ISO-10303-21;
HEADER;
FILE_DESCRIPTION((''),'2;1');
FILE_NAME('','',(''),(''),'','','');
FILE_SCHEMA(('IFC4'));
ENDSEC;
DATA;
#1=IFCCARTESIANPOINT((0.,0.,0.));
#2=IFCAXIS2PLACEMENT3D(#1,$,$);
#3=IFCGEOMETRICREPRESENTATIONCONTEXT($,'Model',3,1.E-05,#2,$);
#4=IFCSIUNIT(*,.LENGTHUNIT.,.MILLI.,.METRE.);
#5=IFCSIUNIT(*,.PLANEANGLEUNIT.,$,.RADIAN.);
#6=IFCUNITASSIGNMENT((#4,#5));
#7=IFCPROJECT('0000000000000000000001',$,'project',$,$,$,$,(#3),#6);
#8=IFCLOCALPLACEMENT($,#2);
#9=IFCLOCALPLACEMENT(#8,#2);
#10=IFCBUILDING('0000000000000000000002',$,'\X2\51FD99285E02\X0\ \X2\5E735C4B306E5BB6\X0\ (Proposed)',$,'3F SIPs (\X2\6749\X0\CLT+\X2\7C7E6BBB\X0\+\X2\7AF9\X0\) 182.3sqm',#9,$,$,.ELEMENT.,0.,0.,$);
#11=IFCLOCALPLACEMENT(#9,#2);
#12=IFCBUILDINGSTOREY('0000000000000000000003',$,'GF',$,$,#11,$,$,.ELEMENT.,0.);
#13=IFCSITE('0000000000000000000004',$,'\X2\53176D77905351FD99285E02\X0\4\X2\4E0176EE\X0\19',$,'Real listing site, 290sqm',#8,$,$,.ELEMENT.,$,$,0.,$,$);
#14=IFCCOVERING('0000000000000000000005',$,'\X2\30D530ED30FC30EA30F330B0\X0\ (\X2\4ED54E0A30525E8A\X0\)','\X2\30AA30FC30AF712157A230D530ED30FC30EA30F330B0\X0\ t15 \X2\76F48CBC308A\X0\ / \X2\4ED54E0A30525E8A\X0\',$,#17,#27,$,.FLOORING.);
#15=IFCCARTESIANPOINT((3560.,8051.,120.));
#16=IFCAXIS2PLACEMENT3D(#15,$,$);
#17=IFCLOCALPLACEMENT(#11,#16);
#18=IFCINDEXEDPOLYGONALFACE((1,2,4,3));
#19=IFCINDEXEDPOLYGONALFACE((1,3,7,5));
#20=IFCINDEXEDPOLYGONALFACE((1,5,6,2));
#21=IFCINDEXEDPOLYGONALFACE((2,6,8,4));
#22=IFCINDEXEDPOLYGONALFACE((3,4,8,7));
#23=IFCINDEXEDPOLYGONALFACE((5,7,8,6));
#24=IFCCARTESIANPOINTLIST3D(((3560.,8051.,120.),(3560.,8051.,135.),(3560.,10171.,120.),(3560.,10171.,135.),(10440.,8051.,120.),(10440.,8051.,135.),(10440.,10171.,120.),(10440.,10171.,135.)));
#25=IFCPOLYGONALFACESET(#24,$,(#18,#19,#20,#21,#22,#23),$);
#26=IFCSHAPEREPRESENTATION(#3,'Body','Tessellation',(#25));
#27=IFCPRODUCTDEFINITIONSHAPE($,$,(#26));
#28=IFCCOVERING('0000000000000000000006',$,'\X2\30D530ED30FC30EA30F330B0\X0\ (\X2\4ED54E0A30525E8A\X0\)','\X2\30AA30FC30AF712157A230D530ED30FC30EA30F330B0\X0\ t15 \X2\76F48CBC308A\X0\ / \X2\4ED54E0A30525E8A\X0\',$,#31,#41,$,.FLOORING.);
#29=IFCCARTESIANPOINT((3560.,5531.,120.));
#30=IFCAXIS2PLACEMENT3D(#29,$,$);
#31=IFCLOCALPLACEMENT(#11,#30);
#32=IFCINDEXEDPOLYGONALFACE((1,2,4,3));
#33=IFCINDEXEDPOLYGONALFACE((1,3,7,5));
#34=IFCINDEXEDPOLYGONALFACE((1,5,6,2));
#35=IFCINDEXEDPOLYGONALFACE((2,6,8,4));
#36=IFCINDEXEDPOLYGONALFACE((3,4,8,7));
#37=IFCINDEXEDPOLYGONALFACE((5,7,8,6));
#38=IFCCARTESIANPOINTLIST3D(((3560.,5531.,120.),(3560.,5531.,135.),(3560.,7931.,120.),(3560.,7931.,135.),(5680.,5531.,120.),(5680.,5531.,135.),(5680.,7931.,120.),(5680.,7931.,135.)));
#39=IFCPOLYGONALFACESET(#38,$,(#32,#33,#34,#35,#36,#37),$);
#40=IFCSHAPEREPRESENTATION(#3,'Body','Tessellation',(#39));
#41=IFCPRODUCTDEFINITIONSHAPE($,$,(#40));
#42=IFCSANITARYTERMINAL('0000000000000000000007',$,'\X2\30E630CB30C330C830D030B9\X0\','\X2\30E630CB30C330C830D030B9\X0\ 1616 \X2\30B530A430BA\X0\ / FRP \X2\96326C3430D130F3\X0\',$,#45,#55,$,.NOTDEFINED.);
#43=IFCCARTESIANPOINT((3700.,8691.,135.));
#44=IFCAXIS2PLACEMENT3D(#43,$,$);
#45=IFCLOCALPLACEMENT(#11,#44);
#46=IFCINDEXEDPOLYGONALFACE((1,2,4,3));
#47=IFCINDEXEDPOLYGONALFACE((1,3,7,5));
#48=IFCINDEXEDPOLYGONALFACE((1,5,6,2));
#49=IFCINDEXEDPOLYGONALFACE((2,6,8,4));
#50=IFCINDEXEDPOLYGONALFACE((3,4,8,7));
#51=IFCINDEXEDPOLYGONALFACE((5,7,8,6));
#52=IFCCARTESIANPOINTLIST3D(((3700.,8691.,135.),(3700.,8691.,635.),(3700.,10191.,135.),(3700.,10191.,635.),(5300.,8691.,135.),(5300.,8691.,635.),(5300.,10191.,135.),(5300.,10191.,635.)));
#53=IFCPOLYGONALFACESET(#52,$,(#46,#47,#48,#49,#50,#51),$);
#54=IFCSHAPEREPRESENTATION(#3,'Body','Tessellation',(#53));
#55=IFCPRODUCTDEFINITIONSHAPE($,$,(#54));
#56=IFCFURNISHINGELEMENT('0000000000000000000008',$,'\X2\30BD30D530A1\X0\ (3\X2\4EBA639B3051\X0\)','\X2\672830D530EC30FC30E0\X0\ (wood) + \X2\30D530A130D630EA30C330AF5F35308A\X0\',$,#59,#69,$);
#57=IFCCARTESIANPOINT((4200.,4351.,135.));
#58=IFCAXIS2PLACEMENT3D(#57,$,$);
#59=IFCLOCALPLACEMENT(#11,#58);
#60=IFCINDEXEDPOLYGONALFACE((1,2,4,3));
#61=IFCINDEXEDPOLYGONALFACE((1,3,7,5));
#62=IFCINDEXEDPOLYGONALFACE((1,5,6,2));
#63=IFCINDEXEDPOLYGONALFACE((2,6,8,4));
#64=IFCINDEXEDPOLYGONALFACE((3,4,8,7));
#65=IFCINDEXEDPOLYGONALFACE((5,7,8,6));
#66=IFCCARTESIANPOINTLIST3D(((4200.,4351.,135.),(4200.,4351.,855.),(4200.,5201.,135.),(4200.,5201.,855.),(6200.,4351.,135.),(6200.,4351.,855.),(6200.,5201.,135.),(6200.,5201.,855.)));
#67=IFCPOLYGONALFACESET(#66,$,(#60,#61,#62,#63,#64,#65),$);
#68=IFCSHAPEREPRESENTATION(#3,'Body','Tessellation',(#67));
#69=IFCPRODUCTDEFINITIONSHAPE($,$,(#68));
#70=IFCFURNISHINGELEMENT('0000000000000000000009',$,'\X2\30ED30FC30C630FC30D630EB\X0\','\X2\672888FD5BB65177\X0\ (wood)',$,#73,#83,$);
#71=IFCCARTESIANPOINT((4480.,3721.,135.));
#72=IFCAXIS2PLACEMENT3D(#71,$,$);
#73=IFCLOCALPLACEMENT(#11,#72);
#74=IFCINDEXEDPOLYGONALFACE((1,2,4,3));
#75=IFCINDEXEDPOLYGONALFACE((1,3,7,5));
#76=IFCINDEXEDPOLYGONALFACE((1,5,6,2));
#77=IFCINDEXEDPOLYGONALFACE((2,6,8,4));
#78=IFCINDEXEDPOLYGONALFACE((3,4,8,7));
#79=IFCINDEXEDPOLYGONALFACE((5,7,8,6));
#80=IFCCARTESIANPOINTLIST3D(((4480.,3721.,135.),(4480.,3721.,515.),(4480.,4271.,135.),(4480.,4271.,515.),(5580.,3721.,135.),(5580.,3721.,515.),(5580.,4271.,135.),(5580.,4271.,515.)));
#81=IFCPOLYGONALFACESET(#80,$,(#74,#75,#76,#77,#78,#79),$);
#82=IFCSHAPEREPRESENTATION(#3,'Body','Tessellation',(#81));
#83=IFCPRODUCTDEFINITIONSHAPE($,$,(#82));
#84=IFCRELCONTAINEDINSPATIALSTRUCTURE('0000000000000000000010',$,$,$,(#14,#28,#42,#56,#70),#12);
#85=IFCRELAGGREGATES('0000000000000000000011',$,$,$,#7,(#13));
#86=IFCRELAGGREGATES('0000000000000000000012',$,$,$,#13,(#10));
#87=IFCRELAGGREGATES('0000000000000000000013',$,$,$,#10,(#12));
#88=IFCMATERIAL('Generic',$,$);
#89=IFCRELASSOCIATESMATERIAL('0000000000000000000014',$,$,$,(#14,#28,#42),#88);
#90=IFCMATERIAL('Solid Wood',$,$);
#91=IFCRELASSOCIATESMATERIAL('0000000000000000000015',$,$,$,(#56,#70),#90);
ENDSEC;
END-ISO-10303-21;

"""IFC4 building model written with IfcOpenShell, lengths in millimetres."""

from ifc_helpers import new_model, si_unit, frame, frame_2d, origin, place, context, project, spatial, rectangle, extrude, material, element, save


model = new_model("IFC4")

# Units and contexts
model_context = context("Model", 3, precision=1e-05, world=origin())
ifc_project = project(units=[si_unit("LENGTHUNIT", "METRE", prefix="MILLI"), si_unit("PLANEANGLEUNIT", "RADIAN")], contexts=[model_context])

# Site, building, storey
site_placement = place(None, origin())
site = spatial("IfcSite", under=ifc_project, at=site_placement, Name="北海道函館市4丁目19", ObjectType="Real listing site, 290sqm", CompositionType="ELEMENT", RefElevation=0.0)
building_placement = place(site_placement, origin())
building = spatial("IfcBuilding", under=site, at=building_placement, Name="函館市 平屋の家 (Proposed)", ObjectType="3F SIPs (杉CLT+籾殻+竹) 182.3sqm", CompositionType="ELEMENT", ElevationOfRefHeight=0.0, ElevationOfTerrain=0.0)
storey_placement = place(building_placement, origin())
storey = spatial("IfcBuildingStorey", under=building, at=storey_placement, Name="GF", CompositionType="ELEMENT", Elevation=0.0)

# Shared definitions
ifc_material_1 = material(Name="Solid Wood")

# Coverings
ifc_material_2 = material(Name="Generic")
covering_1_placement = place(storey_placement, frame((3560.0, 8051.0, 120.0)))
element("IfcCovering", 1, at=covering_1_placement, inside=storey, material=ifc_material_2, Name="フローリング (仕上げ床)", Description="オーク無垢フローリング t15 直貼り / 仕上げ床", PredefinedType="FLOORING", context=model_context, shape_type="SweptSolid", body=[
    extrude(rectangle(XDim=6880.0, YDim=2120.0, at=frame_2d((3440.0, 1060.0))), frame((3560.0, 8051.0, 120.0)), (0.0, 0.0, 1.0), 15.0),
])
covering_2_placement = place(storey_placement, frame((3560.0, 5531.0, 120.0)))
element("IfcCovering", 2, at=covering_2_placement, inside=storey, material=ifc_material_2, Name="フローリング (仕上げ床)", Description="オーク無垢フローリング t15 直貼り / 仕上げ床", PredefinedType="FLOORING", context=model_context, shape_type="SweptSolid", body=[
    extrude(rectangle(XDim=2120.0, YDim=2400.0, at=frame_2d((1060.0, 1200.0))), frame((3560.0, 5531.0, 120.0)), (0.0, 0.0, 1.0), 15.0),
])

# Sanitary terminal
sanitary_terminal_placement = place(storey_placement, frame((3700.0, 8691.0, 135.0)))
element("IfcSanitaryTerminal", 3, at=sanitary_terminal_placement, inside=storey, material=ifc_material_2, Name="ユニットバス", Description="ユニットバス 1616 サイズ / FRP 防水パン", PredefinedType="NOTDEFINED", context=model_context, shape_type="SweptSolid", body=[
    extrude(rectangle(XDim=1600.0, YDim=1500.0, at=frame_2d((800.0, 750.0))), frame((3700.0, 8691.0, 135.0)), (0.0, 0.0, 1.0), 500.0),
])

# Furnishing elements
furnishing_1_placement = place(storey_placement, frame((4200.0, 4351.0, 135.0)))
element("IfcFurnishingElement", 4, at=furnishing_1_placement, inside=storey, material=ifc_material_1, Name="ソファ (3人掛け)", Description="木フレーム (wood) + ファブリック張り", context=model_context, shape_type="SweptSolid", body=[
    extrude(rectangle(XDim=2000.0, YDim=850.0, at=frame_2d((1000.0, 425.0))), frame((4200.0, 4351.0, 135.0)), (0.0, 0.0, 1.0), 720.0),
])
furnishing_2_placement = place(storey_placement, frame((4480.0, 3721.0, 135.0)))
element("IfcFurnishingElement", 5, at=furnishing_2_placement, inside=storey, material=ifc_material_1, Name="ローテーブル", Description="木製家具 (wood)", context=model_context, shape_type="SweptSolid", body=[
    extrude(rectangle(XDim=1100.0, YDim=550.0, at=frame_2d((550.0, 275.0))), frame((4480.0, 3721.0, 135.0)), (0.0, 0.0, 1.0), 380.0),
])

save(model, "model.ifc")
